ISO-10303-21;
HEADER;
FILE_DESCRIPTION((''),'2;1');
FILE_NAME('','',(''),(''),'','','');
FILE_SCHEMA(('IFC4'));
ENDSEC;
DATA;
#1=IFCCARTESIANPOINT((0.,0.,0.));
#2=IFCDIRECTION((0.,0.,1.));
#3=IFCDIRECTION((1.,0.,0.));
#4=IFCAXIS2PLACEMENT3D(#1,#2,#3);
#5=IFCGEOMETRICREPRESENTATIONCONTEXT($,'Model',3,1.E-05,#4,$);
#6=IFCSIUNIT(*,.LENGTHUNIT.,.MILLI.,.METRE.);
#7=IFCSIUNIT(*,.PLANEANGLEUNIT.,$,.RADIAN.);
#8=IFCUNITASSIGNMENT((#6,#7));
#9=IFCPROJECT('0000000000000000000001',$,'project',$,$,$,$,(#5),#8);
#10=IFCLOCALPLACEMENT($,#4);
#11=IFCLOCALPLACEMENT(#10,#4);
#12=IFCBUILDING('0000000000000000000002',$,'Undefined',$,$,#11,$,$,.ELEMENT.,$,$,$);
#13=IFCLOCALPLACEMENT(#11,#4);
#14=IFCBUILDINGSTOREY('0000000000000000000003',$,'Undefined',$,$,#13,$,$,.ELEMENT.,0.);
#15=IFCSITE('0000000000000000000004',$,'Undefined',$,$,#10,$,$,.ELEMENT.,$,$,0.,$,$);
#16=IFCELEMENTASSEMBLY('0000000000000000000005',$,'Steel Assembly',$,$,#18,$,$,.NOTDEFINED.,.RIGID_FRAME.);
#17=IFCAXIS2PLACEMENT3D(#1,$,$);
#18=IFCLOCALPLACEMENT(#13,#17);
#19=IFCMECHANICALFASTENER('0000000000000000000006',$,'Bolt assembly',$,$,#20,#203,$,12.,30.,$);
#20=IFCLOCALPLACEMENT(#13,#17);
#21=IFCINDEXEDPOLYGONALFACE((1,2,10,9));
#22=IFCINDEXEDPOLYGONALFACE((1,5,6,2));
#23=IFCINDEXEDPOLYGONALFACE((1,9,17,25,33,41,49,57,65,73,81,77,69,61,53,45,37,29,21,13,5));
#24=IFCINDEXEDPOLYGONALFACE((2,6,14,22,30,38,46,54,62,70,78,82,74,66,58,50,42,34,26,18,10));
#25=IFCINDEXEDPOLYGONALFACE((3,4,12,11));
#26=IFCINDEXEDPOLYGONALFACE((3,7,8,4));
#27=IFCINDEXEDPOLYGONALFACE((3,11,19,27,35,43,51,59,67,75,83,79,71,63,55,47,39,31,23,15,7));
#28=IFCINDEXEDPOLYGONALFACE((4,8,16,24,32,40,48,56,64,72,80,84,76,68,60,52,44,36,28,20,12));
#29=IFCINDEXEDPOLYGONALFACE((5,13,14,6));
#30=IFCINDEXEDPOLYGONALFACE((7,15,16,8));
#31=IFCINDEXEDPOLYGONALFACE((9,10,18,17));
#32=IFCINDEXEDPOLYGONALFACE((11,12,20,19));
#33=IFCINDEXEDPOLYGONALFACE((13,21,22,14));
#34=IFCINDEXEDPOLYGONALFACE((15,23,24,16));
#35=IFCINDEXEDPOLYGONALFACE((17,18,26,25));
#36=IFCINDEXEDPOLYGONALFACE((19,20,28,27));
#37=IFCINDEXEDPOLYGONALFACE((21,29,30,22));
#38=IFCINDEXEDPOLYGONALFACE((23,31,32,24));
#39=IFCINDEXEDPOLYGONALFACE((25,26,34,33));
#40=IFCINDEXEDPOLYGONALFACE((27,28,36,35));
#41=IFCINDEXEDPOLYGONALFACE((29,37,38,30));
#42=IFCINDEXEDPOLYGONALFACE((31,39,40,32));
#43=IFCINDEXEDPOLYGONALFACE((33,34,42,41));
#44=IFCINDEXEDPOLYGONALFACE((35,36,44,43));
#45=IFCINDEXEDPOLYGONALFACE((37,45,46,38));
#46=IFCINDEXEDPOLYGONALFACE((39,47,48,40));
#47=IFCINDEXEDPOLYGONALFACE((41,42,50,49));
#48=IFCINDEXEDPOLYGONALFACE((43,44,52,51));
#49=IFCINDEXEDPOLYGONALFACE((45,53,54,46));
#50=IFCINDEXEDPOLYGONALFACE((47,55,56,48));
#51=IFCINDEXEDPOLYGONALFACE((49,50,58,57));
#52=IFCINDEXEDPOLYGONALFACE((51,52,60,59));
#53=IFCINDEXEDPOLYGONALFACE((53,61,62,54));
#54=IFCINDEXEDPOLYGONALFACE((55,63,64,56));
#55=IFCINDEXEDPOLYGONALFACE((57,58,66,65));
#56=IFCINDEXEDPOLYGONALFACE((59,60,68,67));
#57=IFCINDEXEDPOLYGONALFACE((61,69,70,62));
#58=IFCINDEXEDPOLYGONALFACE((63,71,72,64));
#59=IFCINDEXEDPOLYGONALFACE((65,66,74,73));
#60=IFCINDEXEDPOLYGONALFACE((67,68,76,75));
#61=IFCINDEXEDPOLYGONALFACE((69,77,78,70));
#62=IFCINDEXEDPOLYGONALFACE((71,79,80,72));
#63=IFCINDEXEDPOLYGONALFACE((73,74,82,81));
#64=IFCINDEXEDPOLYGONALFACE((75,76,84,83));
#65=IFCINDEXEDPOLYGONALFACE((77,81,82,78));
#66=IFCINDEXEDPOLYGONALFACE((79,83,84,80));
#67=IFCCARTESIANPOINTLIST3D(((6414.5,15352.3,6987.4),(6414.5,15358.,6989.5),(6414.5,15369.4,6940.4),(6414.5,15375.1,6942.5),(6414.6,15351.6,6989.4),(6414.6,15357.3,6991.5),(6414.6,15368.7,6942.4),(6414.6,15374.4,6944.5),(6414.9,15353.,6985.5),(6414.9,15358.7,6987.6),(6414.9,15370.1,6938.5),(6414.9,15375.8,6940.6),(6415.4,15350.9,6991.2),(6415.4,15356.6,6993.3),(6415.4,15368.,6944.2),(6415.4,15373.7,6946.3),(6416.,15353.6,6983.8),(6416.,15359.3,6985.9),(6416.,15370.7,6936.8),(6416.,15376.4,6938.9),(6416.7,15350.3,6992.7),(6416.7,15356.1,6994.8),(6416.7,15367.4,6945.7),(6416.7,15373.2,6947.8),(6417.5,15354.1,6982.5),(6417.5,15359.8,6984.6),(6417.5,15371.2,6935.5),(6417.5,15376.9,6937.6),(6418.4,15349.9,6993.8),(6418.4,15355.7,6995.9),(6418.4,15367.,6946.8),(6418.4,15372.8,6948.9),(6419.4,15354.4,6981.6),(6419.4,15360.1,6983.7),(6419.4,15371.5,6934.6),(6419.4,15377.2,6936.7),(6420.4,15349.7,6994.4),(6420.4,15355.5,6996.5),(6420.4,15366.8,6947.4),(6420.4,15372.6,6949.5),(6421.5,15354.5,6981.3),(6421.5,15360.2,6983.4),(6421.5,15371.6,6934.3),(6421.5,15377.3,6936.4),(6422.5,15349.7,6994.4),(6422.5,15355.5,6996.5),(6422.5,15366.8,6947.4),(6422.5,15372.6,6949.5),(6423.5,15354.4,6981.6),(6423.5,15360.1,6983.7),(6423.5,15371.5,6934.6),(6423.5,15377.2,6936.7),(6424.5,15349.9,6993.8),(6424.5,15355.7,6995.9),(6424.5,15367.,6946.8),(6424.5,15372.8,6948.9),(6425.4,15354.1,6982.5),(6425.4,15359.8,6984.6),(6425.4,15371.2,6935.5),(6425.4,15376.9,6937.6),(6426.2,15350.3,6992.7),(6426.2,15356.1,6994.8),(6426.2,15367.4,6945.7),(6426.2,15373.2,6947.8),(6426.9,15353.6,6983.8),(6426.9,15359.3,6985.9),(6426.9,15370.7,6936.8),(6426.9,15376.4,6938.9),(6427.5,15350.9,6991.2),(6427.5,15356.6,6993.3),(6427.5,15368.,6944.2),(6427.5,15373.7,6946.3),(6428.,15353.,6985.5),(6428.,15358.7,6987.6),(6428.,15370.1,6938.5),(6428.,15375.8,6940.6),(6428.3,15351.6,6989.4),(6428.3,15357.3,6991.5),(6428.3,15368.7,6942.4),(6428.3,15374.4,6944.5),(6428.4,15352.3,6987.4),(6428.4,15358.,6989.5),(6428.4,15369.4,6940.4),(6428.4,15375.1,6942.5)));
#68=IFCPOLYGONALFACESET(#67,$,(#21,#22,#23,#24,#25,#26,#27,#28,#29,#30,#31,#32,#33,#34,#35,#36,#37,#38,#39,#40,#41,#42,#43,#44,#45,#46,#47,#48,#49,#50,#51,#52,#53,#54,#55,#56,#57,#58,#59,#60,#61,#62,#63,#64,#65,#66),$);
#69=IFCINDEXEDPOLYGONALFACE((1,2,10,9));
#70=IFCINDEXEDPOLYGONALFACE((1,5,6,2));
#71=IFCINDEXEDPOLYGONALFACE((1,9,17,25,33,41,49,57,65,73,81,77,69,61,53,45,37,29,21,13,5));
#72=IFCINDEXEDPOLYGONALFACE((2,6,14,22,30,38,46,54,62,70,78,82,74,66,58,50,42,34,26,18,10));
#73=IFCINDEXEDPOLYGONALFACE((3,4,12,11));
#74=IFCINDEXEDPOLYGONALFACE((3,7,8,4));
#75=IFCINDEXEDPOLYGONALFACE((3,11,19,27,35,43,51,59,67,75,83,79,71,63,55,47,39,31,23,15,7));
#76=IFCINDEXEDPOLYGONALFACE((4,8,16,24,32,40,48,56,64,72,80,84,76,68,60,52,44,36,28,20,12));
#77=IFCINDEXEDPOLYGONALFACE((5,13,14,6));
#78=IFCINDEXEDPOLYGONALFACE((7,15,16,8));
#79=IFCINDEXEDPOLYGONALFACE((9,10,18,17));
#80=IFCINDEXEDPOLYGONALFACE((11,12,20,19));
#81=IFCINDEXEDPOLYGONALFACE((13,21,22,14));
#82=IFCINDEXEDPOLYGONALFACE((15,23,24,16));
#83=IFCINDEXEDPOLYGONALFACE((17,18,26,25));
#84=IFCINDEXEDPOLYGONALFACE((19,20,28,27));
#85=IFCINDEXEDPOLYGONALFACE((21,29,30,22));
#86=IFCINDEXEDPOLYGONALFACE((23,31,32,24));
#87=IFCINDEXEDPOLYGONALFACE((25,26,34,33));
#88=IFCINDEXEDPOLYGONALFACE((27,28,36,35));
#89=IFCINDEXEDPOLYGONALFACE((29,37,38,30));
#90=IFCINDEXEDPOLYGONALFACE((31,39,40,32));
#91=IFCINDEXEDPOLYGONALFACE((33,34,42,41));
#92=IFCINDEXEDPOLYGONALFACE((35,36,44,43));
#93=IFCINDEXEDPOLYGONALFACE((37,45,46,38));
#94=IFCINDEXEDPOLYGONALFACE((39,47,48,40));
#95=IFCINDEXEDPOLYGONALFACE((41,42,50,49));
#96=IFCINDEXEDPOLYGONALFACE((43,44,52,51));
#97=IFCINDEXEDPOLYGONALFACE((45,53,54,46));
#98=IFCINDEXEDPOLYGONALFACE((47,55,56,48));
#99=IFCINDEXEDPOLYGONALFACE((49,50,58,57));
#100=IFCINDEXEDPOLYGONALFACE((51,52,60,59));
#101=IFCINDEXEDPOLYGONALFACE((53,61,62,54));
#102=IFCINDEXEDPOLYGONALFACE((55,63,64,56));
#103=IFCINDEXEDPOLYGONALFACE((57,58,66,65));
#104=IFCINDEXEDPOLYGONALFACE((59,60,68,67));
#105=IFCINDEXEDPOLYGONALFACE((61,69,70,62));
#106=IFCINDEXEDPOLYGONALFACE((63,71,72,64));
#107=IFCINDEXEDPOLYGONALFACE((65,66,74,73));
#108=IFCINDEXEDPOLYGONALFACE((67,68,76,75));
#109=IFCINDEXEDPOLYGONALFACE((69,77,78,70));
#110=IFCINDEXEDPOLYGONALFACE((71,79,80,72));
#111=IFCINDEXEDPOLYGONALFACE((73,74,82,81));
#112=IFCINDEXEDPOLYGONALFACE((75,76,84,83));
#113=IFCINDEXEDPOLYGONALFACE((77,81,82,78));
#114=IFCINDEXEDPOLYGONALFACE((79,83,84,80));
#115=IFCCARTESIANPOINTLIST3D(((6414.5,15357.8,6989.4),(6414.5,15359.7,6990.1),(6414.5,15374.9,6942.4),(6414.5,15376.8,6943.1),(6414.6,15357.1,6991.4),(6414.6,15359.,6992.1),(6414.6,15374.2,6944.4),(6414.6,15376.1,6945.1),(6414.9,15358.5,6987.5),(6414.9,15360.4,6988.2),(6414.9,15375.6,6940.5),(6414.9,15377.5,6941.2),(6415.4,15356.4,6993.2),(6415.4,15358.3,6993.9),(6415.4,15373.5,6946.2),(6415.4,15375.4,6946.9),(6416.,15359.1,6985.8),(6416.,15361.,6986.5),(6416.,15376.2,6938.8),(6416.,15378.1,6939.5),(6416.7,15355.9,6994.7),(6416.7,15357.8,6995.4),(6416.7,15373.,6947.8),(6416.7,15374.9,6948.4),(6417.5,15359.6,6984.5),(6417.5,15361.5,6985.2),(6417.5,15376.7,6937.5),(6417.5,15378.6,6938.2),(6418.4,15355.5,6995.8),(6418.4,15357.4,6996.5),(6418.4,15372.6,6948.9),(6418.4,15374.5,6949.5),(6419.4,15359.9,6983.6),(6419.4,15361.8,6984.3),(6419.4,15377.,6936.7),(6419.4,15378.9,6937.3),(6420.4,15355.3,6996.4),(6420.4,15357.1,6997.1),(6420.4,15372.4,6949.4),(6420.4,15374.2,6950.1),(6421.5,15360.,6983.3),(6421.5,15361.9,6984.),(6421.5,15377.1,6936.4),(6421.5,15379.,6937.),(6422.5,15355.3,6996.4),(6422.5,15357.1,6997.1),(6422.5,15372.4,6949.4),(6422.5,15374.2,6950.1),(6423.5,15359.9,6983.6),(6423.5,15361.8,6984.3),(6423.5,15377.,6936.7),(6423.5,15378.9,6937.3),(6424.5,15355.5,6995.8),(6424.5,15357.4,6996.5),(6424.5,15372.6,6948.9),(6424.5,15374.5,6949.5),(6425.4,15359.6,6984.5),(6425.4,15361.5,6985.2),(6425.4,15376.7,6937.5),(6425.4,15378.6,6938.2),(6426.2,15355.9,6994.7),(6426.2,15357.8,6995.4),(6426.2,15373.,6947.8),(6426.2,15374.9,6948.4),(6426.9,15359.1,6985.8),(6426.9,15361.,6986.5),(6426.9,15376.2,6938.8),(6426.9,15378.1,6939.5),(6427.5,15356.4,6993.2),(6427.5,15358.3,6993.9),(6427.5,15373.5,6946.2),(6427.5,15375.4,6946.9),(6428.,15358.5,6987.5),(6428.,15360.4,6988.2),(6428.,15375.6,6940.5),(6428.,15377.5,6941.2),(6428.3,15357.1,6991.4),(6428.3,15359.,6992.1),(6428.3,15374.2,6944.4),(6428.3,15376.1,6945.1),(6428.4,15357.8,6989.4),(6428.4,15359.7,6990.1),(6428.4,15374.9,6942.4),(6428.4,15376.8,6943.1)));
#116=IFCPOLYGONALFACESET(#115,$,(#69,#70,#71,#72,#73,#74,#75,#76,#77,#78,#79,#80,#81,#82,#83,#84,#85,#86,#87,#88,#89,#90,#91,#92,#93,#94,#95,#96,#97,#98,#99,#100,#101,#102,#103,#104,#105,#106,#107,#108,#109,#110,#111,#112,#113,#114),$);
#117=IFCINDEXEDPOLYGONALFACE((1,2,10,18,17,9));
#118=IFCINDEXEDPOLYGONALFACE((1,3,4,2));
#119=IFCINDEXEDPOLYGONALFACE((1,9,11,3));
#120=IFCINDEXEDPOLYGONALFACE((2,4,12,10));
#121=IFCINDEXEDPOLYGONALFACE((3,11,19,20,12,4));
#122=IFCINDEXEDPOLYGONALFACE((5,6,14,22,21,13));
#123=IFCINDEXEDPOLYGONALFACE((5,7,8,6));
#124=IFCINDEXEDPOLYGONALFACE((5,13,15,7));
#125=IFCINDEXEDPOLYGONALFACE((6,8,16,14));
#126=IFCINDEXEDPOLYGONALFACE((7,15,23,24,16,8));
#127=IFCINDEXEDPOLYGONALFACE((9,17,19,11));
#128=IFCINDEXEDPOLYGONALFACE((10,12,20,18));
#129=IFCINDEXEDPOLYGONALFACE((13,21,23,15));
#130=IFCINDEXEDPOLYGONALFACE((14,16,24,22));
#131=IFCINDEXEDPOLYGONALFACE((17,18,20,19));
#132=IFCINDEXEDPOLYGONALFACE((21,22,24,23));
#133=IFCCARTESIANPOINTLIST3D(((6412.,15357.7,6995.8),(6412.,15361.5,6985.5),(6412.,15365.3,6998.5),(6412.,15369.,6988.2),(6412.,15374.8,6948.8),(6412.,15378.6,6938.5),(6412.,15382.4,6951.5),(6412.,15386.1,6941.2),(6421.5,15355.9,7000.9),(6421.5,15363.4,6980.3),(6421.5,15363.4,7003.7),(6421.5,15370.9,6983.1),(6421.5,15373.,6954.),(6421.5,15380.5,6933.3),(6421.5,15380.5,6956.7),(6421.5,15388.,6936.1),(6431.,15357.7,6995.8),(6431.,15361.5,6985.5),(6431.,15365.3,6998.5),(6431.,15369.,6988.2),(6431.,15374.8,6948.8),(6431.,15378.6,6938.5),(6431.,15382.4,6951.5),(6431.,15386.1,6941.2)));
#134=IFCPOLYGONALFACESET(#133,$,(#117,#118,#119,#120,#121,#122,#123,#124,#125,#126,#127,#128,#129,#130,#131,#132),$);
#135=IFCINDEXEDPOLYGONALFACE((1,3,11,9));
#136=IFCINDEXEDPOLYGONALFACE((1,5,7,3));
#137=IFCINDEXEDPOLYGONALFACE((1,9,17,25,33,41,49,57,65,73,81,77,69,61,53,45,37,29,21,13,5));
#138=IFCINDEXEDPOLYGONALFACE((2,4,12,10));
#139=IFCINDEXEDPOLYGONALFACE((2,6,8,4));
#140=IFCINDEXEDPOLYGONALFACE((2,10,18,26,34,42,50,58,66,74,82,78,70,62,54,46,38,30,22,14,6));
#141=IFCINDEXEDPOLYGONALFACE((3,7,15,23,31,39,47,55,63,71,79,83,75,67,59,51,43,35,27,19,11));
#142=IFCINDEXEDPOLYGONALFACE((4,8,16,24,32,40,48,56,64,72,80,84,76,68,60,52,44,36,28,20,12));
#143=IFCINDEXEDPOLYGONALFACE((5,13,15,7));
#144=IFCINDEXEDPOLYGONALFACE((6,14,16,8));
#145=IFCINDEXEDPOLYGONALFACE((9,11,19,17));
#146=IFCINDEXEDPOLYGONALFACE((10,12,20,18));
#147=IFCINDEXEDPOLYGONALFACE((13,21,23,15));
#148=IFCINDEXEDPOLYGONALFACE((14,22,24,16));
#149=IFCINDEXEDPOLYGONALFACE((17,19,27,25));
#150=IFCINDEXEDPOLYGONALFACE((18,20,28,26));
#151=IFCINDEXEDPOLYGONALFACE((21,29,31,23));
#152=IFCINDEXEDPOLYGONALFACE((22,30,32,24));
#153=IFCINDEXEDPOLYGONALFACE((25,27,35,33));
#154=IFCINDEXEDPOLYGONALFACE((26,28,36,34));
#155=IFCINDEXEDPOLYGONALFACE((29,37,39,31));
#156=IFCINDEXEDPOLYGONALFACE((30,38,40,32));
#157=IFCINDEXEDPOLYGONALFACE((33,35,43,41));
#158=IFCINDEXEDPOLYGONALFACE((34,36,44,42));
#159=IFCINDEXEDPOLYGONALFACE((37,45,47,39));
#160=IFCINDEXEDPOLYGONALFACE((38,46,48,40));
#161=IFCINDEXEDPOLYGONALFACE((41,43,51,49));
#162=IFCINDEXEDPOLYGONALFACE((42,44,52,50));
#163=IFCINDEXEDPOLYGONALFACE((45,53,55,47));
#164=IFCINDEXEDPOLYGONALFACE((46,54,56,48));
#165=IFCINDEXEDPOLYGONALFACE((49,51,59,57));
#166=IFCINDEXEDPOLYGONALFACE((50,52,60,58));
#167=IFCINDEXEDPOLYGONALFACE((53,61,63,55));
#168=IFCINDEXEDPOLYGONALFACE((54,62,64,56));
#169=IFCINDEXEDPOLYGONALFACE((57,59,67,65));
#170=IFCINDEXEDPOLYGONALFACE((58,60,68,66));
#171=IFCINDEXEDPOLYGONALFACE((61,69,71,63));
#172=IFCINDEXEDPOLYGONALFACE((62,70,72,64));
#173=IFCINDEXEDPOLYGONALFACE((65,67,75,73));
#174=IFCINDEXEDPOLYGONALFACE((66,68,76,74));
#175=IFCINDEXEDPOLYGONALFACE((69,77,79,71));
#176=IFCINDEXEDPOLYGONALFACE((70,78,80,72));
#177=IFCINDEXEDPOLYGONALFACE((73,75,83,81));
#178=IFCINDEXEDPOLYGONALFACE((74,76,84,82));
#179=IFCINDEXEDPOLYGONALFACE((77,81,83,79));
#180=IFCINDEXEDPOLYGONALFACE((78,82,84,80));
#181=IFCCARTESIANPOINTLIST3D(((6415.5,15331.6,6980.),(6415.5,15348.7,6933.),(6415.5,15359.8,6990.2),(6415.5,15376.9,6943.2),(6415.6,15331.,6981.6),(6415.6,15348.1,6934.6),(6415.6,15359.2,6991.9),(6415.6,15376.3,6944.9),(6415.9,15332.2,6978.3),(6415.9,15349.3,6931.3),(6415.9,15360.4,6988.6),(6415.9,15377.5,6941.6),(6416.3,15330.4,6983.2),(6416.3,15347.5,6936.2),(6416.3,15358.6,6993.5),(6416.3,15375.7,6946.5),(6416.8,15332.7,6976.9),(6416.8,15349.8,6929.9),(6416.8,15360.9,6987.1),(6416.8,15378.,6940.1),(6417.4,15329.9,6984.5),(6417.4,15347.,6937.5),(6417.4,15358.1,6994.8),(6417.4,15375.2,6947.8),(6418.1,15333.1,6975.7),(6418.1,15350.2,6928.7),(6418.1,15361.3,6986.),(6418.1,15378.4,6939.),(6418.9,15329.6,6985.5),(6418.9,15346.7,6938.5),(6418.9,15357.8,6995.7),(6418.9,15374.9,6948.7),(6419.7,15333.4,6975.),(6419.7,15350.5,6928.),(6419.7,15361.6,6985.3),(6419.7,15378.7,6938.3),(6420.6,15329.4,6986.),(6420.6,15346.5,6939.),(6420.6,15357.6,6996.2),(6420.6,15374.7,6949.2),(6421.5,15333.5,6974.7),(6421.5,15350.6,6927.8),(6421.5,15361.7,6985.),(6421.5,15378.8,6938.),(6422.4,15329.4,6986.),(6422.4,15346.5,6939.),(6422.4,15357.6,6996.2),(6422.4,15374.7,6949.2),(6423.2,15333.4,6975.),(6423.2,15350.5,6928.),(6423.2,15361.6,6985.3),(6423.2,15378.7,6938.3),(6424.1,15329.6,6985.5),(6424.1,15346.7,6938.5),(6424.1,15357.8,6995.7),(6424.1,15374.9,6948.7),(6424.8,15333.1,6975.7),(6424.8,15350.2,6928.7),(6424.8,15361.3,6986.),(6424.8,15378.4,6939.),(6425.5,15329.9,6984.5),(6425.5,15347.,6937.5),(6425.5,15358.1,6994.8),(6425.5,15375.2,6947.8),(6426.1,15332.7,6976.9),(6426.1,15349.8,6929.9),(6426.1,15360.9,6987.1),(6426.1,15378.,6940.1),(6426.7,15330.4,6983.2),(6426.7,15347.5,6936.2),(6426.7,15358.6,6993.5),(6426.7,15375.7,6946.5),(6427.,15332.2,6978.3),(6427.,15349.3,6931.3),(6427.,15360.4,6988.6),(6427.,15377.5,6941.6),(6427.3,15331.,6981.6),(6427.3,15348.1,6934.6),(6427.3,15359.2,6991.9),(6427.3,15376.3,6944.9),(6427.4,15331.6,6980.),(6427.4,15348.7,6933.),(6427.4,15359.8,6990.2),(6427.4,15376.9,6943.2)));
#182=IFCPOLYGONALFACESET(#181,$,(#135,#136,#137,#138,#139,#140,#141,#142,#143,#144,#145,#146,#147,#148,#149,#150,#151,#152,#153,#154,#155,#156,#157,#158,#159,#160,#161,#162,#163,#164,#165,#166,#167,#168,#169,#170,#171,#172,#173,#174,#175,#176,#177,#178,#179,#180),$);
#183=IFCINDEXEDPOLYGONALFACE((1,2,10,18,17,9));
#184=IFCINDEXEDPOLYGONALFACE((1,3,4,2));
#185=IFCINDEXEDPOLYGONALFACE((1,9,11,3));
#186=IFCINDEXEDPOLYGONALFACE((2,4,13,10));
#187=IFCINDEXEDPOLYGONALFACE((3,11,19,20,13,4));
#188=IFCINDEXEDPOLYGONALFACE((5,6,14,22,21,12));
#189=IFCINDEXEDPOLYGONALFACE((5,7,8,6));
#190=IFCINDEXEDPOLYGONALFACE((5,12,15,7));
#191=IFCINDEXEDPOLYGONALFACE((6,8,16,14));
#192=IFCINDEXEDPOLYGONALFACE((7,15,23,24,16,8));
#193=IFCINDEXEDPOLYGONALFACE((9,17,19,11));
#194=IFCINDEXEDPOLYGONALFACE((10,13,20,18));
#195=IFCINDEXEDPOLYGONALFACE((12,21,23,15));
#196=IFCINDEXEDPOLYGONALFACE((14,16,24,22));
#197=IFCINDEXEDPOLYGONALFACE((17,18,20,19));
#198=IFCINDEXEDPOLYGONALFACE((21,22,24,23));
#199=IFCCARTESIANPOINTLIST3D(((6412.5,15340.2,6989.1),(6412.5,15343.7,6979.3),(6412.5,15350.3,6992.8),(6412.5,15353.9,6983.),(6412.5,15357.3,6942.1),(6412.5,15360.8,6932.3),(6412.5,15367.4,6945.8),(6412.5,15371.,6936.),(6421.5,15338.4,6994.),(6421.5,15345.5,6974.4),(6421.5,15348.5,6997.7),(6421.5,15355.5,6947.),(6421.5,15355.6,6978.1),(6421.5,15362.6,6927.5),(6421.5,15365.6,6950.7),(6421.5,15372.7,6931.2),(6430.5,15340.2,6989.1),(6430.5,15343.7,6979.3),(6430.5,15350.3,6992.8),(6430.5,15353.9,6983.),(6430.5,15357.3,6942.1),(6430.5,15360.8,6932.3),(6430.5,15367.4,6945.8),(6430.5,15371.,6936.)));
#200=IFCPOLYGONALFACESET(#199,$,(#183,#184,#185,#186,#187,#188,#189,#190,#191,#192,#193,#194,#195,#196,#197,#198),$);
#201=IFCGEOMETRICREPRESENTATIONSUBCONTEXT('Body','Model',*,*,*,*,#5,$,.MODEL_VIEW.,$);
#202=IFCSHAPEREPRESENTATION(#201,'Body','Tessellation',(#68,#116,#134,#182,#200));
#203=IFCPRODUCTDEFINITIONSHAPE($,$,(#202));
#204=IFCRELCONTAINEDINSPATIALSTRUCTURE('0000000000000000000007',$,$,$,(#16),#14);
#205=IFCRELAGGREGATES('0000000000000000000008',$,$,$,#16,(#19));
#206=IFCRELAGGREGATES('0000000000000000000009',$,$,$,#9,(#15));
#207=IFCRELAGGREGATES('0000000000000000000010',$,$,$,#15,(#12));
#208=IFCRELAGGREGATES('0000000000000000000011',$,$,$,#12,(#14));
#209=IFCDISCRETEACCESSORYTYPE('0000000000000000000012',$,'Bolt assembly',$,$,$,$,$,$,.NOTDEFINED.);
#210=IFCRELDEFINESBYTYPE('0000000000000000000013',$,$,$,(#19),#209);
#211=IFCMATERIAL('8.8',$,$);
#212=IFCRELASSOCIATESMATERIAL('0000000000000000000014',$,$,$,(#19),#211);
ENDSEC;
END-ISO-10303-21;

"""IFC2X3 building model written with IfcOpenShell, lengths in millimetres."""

from ifc_helpers import new_model, si_unit, frame, origin_with_axes, origin_2d_with_axis, place, context, subcontext, project, spatial, polyline, circle, outline, extrude, source, transform, mapped, material, type_object, element, aggregate, save


model = new_model("IFC2X3")

# Units and contexts
model_context = context("Model", 3, precision=1e-05, world=origin_with_axes())
body_context = subcontext(model_context, "Body", "Model", "MODEL_VIEW")
ifc_project = project(units=[si_unit("LENGTHUNIT", "METRE", prefix="MILLI"), si_unit("PLANEANGLEUNIT", "RADIAN")], contexts=[model_context])

# Site, building, storey
site_placement = place(None, origin_with_axes())
site = spatial("IfcSite", under=ifc_project, at=site_placement, Name="Undefined", CompositionType="ELEMENT", RefElevation=0.0)
building_placement = place(site_placement, origin_with_axes())
building = spatial("IfcBuilding", under=site, at=building_placement, Name="Undefined", CompositionType="ELEMENT")
storey_placement = place(building_placement, origin_with_axes())
storey = spatial("IfcBuildingStorey", under=building, at=storey_placement, Name="Undefined", CompositionType="ELEMENT", Elevation=0.0)

# Element assembly
assembly_1_placement = place(storey_placement, origin_with_axes())
assembly_1 = element("IfcElementAssembly", 1, at=assembly_1_placement, inside=storey, Name="Steel Assembly", AssemblyPlace="NOTDEFINED", PredefinedType="RIGID_FRAME")

# Shared definitions
ifc_material_1 = material(Name="8.8")
discrete_accessory_type_1 = type_object("IfcDiscreteAccessoryType", Name="Bolt assembly")

# Shared definitions
shared_shape_1 = source(origin_with_axes(), body_context, "Body", "SweptSolid", [
    extrude(circle(Radius=7.0, at=origin_2d_with_axis()), frame((0.0, -6.1, 0.0), z_axis=(0.0, 1.0, 0.0), x_axis=(1.0, 0.0, 0.0)), (0.0, 0.0, 1.0), 6.1),
    extrude(circle(Radius=7.0, at=origin_2d_with_axis()), frame((0.0, -7.9, 0.0), z_axis=(0.0, 1.0, 0.0), x_axis=(1.0, 0.0, 0.0)), (0.0, 0.0, 1.0), 2.0),
    extrude(outline(polyline([(11.0, 0.0), (5.5, 9.5), (-5.5, 9.5), (-11.0, 0.0), (-5.5, -9.5), (5.5, -9.5), (11.0, 0.0)])), frame((0.0, -16.0, 0.0), z_axis=(0.0, 1.0, 0.0), x_axis=(1.0, 0.0, 0.0)), (0.0, 0.0, 1.0), 8.0),
    extrude(circle(Radius=6.0, at=origin_2d_with_axis()), frame((0.0, -8.0, 0.0), z_axis=(0.0, 1.0, 0.0), x_axis=(1.0, 0.0, 0.0)), (0.0, 0.0, 1.0), 30.0),
    extrude(outline(polyline([(10.4, 0.0), (5.2, 9.0), (-5.2, 9.0), (-10.4, 0.0), (-5.2, -9.0), (5.2, -9.0), (10.4, 0.0)])), frame((0.0, 0.0, 0.0), z_axis=(0.0, 1.0, 0.0), x_axis=(1.0, 0.0, 0.0)), (0.0, 0.0, 1.0), 10.8),
])

# Mechanical fastener
mechanical_fastener_1_placement = place(assembly_1_placement, frame((6421.5, 15352.1, 6987.9), z_axis=(-1.0, 0.0, 0.0), x_axis=(0.0, 0.34202, -0.939693)))
mechanical_fastener_1 = element("IfcMechanicalFastener", 2, at=mechanical_fastener_1_placement, type_object=discrete_accessory_type_1, material=ifc_material_1, Name="Bolt assembly", NominalDiameter=12.0, NominalLength=30.0, context=body_context, shape_type="MappedRepresentation", body=[
    mapped(shared_shape_1, transform((0.0, 0.0, 0.0))),
    mapped(shared_shape_1, transform((50.0, 0.0, 0.0))),
])
aggregate(assembly_1, [mechanical_fastener_1])

save(model, "model.ifc")
